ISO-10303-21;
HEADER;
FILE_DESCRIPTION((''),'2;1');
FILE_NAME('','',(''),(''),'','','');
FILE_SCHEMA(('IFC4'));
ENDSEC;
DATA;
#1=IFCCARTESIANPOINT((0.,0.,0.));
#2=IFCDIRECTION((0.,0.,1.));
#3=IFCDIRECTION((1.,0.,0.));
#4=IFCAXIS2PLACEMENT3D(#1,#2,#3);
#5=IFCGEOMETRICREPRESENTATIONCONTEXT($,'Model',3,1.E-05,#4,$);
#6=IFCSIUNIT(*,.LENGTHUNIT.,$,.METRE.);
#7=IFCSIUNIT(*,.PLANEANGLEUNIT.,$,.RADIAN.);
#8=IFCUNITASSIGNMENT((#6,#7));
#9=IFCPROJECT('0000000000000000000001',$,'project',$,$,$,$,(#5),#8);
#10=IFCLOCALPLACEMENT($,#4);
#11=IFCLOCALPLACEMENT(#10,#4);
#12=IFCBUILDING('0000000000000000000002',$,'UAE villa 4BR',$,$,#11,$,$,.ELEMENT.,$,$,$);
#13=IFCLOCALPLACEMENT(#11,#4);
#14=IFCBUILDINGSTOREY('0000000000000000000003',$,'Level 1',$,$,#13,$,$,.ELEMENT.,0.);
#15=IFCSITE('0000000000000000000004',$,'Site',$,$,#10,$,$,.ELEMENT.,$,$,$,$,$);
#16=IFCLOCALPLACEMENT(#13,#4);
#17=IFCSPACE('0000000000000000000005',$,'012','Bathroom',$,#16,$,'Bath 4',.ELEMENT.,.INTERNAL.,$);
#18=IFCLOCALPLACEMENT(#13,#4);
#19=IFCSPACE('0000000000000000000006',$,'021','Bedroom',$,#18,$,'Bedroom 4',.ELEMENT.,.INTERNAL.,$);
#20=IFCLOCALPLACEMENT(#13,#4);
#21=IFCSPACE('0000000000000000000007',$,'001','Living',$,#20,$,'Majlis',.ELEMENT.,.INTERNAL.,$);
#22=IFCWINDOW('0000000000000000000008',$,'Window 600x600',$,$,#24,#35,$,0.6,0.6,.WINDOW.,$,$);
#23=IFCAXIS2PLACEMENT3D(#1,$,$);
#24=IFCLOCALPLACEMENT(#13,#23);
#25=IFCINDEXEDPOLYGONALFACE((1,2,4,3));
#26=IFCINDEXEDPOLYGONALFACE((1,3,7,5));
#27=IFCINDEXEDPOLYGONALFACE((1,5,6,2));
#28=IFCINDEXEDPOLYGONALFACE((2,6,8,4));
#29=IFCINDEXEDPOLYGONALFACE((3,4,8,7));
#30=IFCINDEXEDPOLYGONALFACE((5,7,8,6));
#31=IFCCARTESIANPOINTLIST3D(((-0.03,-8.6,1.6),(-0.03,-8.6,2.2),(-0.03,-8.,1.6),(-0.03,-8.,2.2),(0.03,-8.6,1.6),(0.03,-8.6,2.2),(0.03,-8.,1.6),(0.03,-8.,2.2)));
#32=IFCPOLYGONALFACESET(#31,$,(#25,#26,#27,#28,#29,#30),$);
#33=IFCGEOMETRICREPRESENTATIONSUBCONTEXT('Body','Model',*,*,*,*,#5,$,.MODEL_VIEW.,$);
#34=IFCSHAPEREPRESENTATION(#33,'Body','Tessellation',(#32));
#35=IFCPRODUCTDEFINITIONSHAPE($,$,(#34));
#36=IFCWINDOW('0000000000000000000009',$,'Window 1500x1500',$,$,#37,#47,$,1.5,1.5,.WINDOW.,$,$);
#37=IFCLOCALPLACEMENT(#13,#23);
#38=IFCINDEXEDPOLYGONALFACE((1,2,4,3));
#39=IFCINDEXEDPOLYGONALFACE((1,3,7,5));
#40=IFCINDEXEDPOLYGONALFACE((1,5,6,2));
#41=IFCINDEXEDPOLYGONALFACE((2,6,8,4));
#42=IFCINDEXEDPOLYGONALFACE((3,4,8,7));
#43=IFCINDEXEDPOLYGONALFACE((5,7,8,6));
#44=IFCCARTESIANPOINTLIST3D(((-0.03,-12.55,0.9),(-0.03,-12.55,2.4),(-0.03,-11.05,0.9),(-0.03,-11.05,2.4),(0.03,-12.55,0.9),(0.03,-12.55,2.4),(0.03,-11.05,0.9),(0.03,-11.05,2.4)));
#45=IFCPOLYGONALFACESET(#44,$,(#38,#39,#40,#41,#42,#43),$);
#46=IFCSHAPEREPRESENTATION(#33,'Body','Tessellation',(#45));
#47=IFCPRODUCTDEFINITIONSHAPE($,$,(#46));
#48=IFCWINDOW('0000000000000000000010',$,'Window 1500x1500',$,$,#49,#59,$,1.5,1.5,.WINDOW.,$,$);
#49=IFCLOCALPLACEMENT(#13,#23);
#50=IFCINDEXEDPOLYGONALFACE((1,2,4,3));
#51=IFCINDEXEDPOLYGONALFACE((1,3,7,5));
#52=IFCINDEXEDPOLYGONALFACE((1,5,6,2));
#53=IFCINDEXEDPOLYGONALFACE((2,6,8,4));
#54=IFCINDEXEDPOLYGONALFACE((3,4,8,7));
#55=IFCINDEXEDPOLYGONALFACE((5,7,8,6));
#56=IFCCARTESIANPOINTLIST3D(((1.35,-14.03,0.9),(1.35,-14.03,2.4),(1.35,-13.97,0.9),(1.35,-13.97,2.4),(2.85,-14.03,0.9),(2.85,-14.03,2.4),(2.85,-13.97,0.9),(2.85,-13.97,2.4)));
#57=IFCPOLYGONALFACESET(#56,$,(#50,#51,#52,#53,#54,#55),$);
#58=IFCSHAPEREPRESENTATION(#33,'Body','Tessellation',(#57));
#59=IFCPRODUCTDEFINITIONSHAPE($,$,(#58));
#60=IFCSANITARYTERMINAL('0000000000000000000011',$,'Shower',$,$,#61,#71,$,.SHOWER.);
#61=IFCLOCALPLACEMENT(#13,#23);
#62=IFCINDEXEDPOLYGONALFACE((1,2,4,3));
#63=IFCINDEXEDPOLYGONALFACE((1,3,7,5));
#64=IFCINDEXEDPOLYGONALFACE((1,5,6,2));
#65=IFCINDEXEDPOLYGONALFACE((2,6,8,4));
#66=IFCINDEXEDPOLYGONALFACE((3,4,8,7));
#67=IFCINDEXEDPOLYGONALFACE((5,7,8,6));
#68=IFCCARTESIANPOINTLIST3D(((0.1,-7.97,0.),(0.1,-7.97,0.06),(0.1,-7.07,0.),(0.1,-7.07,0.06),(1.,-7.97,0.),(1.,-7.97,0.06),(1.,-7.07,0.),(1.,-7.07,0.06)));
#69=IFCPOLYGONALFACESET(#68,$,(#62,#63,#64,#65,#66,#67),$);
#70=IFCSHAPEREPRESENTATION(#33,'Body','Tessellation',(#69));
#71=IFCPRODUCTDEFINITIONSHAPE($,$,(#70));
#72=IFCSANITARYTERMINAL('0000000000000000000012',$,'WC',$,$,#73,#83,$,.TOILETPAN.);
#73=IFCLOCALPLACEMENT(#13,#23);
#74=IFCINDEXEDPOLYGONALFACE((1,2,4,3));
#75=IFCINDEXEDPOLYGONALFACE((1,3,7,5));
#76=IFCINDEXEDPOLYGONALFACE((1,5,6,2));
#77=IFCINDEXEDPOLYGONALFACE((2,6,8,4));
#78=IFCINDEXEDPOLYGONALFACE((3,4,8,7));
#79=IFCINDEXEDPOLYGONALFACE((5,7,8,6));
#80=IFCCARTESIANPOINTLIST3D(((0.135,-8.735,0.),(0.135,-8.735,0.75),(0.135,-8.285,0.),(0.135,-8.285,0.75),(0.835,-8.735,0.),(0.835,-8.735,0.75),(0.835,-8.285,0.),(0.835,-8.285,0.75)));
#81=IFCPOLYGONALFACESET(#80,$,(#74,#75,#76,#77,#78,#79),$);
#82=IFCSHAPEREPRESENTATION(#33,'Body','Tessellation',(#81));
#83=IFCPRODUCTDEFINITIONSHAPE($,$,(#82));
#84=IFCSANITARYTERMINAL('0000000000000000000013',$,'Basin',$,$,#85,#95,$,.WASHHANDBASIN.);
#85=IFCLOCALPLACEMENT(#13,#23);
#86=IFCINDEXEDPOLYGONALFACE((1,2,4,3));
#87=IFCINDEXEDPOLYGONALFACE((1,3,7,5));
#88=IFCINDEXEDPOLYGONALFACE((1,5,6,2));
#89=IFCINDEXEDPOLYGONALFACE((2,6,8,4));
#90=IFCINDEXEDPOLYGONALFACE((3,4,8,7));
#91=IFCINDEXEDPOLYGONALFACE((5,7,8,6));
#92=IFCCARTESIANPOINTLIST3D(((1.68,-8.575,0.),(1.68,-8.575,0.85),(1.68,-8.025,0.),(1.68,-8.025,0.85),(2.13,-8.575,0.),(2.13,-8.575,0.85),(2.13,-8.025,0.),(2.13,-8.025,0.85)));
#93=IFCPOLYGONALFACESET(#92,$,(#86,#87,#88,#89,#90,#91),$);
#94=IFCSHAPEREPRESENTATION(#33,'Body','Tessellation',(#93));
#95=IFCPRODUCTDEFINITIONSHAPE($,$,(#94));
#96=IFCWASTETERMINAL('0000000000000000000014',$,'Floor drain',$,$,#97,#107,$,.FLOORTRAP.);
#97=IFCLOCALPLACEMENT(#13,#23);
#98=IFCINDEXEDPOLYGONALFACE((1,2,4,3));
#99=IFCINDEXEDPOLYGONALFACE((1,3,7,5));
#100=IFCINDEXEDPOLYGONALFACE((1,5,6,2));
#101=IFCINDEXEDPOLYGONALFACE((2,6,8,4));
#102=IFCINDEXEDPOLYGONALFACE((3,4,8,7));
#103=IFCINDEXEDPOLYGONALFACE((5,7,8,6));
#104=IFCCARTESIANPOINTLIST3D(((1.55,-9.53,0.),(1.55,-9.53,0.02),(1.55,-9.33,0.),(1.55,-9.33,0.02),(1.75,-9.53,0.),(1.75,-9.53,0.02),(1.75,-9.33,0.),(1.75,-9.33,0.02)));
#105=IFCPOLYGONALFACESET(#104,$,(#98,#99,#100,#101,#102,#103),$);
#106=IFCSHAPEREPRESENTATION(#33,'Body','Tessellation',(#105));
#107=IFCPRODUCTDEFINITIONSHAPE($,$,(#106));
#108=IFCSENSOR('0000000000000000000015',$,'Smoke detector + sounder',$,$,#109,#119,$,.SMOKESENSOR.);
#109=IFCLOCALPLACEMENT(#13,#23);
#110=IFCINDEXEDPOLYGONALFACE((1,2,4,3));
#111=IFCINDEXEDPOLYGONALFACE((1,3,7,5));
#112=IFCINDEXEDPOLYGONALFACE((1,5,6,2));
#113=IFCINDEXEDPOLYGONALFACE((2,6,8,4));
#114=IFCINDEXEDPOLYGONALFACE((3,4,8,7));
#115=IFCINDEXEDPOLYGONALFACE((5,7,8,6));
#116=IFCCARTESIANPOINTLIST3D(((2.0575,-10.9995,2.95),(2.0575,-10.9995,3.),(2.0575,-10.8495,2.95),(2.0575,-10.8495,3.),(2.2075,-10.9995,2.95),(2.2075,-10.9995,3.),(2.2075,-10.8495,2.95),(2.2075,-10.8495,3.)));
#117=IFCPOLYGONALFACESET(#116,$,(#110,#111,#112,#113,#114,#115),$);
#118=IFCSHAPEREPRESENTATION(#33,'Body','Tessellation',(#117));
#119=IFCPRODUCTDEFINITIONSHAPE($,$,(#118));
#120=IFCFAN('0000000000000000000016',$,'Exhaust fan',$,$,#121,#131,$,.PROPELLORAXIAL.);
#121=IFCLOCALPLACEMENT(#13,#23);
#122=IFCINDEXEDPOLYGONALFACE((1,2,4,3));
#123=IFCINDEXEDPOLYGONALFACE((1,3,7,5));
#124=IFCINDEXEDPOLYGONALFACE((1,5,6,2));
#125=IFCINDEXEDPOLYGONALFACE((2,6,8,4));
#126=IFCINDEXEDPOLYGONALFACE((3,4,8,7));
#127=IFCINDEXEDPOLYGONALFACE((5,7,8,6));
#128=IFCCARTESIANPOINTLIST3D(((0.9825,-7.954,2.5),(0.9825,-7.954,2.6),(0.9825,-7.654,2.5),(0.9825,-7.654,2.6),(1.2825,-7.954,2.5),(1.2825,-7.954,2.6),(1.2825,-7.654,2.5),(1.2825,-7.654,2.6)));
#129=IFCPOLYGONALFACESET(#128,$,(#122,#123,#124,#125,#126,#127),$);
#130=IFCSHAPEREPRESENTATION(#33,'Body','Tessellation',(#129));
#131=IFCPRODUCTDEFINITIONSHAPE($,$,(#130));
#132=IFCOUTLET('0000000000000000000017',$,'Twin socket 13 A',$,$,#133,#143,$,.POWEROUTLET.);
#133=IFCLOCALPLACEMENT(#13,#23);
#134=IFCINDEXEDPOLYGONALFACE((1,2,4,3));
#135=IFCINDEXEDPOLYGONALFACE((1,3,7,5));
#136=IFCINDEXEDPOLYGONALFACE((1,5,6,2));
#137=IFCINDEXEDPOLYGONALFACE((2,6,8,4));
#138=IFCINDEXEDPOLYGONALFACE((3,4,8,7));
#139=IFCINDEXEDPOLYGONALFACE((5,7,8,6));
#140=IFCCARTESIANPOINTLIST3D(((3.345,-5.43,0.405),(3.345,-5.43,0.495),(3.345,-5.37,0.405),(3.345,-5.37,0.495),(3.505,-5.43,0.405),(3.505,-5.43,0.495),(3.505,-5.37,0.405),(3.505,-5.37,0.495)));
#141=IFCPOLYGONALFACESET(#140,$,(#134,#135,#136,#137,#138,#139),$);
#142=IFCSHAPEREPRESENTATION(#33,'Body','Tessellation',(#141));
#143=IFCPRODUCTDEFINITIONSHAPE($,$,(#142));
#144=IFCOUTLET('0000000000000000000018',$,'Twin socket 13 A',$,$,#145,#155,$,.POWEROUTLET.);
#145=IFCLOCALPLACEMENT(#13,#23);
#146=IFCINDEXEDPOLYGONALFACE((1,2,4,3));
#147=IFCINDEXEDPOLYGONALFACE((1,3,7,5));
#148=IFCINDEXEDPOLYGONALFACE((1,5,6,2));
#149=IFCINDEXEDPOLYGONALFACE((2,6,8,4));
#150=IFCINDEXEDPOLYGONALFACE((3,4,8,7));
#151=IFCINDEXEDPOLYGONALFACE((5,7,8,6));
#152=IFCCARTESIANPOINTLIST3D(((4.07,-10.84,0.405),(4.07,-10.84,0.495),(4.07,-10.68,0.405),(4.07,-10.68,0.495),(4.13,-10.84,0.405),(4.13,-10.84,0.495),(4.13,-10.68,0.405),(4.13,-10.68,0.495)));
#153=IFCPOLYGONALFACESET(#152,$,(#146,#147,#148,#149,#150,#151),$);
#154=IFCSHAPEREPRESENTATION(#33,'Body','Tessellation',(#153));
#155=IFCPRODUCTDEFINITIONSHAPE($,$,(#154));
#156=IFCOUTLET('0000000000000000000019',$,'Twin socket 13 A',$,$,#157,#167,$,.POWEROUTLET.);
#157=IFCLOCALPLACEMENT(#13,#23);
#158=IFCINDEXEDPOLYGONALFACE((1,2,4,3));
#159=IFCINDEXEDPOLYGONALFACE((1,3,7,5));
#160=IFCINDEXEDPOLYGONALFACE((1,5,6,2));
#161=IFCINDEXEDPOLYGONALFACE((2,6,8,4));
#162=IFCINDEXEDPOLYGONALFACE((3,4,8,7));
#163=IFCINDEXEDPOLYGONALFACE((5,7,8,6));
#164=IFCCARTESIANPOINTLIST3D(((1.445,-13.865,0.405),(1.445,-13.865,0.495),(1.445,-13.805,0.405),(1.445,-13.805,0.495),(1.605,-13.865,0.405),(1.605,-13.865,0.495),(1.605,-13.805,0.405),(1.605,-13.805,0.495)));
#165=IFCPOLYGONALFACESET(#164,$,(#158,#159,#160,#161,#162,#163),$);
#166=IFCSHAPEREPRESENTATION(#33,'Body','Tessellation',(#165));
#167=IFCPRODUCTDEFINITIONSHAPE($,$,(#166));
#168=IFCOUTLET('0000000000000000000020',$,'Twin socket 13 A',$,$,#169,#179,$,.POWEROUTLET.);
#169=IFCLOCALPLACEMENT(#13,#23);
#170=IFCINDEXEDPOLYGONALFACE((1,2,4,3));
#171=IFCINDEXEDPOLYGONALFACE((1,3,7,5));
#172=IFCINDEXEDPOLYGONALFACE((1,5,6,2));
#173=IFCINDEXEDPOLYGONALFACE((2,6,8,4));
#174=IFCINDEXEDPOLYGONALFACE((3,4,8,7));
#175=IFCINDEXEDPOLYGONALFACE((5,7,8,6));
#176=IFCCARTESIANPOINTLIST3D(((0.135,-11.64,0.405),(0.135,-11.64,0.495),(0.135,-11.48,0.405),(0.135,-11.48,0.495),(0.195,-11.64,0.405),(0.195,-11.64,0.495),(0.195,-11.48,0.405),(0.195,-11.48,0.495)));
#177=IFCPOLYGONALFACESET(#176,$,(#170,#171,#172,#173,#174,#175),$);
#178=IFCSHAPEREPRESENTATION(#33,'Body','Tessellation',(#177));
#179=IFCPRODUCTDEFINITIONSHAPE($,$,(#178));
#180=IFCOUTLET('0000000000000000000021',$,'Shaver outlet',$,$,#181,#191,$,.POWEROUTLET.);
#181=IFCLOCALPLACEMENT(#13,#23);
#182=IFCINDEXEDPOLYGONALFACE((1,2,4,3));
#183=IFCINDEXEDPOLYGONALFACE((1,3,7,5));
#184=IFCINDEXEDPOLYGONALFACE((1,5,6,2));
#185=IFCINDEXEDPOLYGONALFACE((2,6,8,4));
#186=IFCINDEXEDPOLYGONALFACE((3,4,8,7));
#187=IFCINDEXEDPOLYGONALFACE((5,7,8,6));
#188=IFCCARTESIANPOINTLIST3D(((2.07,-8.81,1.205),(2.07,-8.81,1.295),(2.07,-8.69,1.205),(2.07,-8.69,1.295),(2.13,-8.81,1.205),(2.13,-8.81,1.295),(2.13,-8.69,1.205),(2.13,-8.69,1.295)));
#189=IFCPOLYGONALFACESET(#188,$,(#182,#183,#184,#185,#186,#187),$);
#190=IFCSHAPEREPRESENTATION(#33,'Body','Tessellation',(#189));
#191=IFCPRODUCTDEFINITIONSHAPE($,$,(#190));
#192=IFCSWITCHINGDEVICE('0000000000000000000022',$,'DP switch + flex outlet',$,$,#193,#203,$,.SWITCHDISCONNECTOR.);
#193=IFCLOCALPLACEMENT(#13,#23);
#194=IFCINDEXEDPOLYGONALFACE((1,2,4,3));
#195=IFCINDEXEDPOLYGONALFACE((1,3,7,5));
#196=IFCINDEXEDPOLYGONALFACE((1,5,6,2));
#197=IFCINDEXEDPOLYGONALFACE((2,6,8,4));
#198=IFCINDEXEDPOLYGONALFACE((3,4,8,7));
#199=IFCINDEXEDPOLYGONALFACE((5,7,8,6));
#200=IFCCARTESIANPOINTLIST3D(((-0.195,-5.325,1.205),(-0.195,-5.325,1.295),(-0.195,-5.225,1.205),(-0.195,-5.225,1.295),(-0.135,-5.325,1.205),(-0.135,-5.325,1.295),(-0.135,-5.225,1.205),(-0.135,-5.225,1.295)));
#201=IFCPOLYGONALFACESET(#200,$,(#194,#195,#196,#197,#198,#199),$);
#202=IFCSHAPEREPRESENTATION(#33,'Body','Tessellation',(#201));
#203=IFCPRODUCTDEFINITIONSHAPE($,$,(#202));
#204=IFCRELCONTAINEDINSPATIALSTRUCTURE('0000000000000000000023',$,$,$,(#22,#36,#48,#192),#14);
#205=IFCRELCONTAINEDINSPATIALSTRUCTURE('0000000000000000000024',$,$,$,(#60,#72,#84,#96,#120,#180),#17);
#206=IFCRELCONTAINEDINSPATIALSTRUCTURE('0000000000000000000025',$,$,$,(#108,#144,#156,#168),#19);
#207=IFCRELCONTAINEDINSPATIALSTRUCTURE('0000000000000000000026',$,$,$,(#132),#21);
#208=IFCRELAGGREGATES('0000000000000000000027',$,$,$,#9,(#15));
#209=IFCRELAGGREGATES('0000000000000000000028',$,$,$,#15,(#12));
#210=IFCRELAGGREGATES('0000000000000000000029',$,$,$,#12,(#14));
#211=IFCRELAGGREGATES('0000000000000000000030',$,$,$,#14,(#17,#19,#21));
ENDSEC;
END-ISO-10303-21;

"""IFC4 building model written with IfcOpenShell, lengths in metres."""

from ifc_helpers import new_model, si_unit, frame, origin, origin_with_axes, origin_2d, place, context, subcontext, project, spatial, rectangle, extrude, element, save


model = new_model("IFC4")

# Units and contexts
model_context = context("Model", 3, precision=1e-05, world=origin_with_axes())
body_context = subcontext(model_context, "Body", "Model", "MODEL_VIEW")
ifc_project = project(units=[si_unit("LENGTHUNIT", "METRE"), si_unit("PLANEANGLEUNIT", "RADIAN")], contexts=[model_context])

# Site, building, storey
site_placement = place(None, origin_with_axes())
site = spatial("IfcSite", under=ifc_project, at=site_placement, Name="Site", CompositionType="ELEMENT")
building_placement = place(site_placement, origin_with_axes())
building = spatial("IfcBuilding", under=site, at=building_placement, Name="UAE villa 4BR", CompositionType="ELEMENT")
storey_placement = place(building_placement, origin_with_axes())
storey = spatial("IfcBuildingStorey", under=building, at=storey_placement, Name="Level 1", CompositionType="ELEMENT", Elevation=0.0)

# Windows
window_1_placement = place(storey_placement, frame((0.0, -8.3, 1.6), z_axis=(0.0, 0.0, 1.0), x_axis=(0.0, 1.0, 0.0)))
element("IfcWindow", 1, at=window_1_placement, inside=storey, Name="Window 600x600", OverallHeight=0.6, OverallWidth=0.6, PredefinedType="WINDOW", context=body_context, shape_type="SweptSolid", body=[
    extrude(rectangle(XDim=0.6, YDim=0.06, at=origin_2d()), origin(), (0.0, 0.0, 1.0), 0.6),
])
for number, where, z_axis, x_axis, name in (
    (2, (0.0, -11.8, 0.9), (0.0, 0.0, 1.0), (0.0, 1.0, 0.0), "Window 1500x1500"),
    (3, (2.1, -14.0, 0.9), (0.0, 0.0, 1.0), (-1.0, 0.0, 0.0), "Window 1500x1500"),
):
    element("IfcWindow", number, at=place(storey_placement, frame(where, z_axis=z_axis, x_axis=x_axis)), inside=storey, Name=name, OverallHeight=1.5, OverallWidth=1.5, PredefinedType="WINDOW", context=body_context, shape_type="SweptSolid", body=[
        extrude(rectangle(XDim=1.5, YDim=0.06, at=origin_2d()), origin(), (0.0, 0.0, 1.0), 1.5),
    ])

# Shared definitions
space_1_placement = place(storey_placement, origin_with_axes())
space_1 = spatial("IfcSpace", under=storey, at=space_1_placement, Name="012", Description="Bathroom", LongName="Bath 4", CompositionType="ELEMENT", PredefinedType="INTERNAL")

# Sanitary terminals
sanitary_terminal_1_placement = place(storey_placement, frame((0.55, -7.52, 0.0), z_axis=(0.0, 0.0, 1.0), x_axis=(1.0, 0.0, 0.0)))
element("IfcSanitaryTerminal", 4, at=sanitary_terminal_1_placement, inside=space_1, Name="Shower", PredefinedType="SHOWER", context=body_context, shape_type="SweptSolid", body=[
    extrude(rectangle(XDim=0.9, YDim=0.9, at=origin_2d()), origin(), (0.0, 0.0, 1.0), 0.06),
])
sanitary_terminal_2_placement = place(storey_placement, frame((0.485, -8.51, 0.0), z_axis=(0.0, 0.0, 1.0), x_axis=(0.0, 1.0, 0.0)))
element("IfcSanitaryTerminal", 5, at=sanitary_terminal_2_placement, inside=space_1, Name="WC", PredefinedType="TOILETPAN", context=body_context, shape_type="SweptSolid", body=[
    extrude(rectangle(XDim=0.45, YDim=0.7, at=origin_2d()), origin(), (0.0, 0.0, 1.0), 0.75),
])
sanitary_terminal_3_placement = place(storey_placement, frame((1.905, -8.3, 0.0), z_axis=(0.0, 0.0, 1.0), x_axis=(0.0, -1.0, 0.0)))
element("IfcSanitaryTerminal", 6, at=sanitary_terminal_3_placement, inside=space_1, Name="Basin", PredefinedType="WASHHANDBASIN", context=body_context, shape_type="SweptSolid", body=[
    extrude(rectangle(XDim=0.55, YDim=0.45, at=origin_2d()), origin(), (0.0, 0.0, 1.0), 0.85),
])

# Waste terminal
waste_terminal_placement = place(storey_placement, frame((1.65, -9.43, 0.0), z_axis=(0.0, 0.0, 1.0), x_axis=(-1.0, 0.0, 0.0)))
element("IfcWasteTerminal", 7, at=waste_terminal_placement, inside=space_1, Name="Floor drain", PredefinedType="FLOORTRAP", context=body_context, shape_type="SweptSolid", body=[
    extrude(rectangle(XDim=0.2, YDim=0.2, at=origin_2d()), origin(), (0.0, 0.0, 1.0), 0.02),
])

# Shared definitions
space_2_placement = place(storey_placement, origin_with_axes())
space_2 = spatial("IfcSpace", under=storey, at=space_2_placement, Name="021", Description="Bedroom", LongName="Bedroom 4", CompositionType="ELEMENT", PredefinedType="INTERNAL")

# Sensor
sensor_placement = place(storey_placement, frame((2.1325, -10.9245, 2.95), z_axis=(0.0, 0.0, 1.0), x_axis=(1.0, 0.0, 0.0)))
element("IfcSensor", 8, at=sensor_placement, inside=space_2, Name="Smoke detector + sounder", PredefinedType="SMOKESENSOR", context=body_context, shape_type="SweptSolid", body=[
    extrude(rectangle(XDim=0.15, YDim=0.15, at=origin_2d()), origin(), (0.0, 0.0, 1.0), 0.05),
])

# Fan
fan_placement = place(storey_placement, frame((1.1325, -7.804, 2.5), z_axis=(0.0, 0.0, 1.0), x_axis=(1.0, 0.0, 0.0)))
element("IfcFan", 9, at=fan_placement, inside=space_1, Name="Exhaust fan", PredefinedType="PROPELLORAXIAL", context=body_context, shape_type="SweptSolid", body=[
    extrude(rectangle(XDim=0.3, YDim=0.3, at=origin_2d()), origin(), (0.0, 0.0, 1.0), 0.1),
])

# Shared definitions
space_3_placement = place(storey_placement, origin_with_axes())
space_3 = spatial("IfcSpace", under=storey, at=space_3_placement, Name="001", Description="Living", LongName="Majlis", CompositionType="ELEMENT", PredefinedType="INTERNAL")

# Outlets
outlet_1_placement = place(storey_placement, frame((3.425, -5.4, 0.405), z_axis=(0.0, 0.0, 1.0), x_axis=(-1.0, 0.0, 0.0)))
element("IfcOutlet", 10, at=outlet_1_placement, inside=space_3, Name="Twin socket 13 A", PredefinedType="POWEROUTLET", context=body_context, shape_type="SweptSolid", body=[
    extrude(rectangle(XDim=0.16, YDim=0.06, at=origin_2d()), origin(), (0.0, 0.0, 1.0), 0.09),
])
for number, where, z_axis, x_axis, name in (
    (11, (4.1, -10.76, 0.405), (0.0, 0.0, 1.0), (0.0, -1.0, 0.0), "Twin socket 13 A"),
    (12, (1.525, -13.835, 0.405), (0.0, 0.0, 1.0), (-1.0, 0.0, 0.0), "Twin socket 13 A"),
    (13, (0.165, -11.56, 0.405), (0.0, 0.0, 1.0), (0.0, 1.0, 0.0), "Twin socket 13 A"),
):
    element("IfcOutlet", number, at=place(storey_placement, frame(where, z_axis=z_axis, x_axis=x_axis)), inside=space_2, Name=name, PredefinedType="POWEROUTLET", context=body_context, shape_type="SweptSolid", body=[
        extrude(rectangle(XDim=0.16, YDim=0.06, at=origin_2d()), origin(), (0.0, 0.0, 1.0), 0.09),
    ])
outlet_2_placement = place(storey_placement, frame((2.1, -8.75, 1.205), z_axis=(0.0, 0.0, 1.0), x_axis=(0.0, -1.0, 0.0)))
element("IfcOutlet", 14, at=outlet_2_placement, inside=space_1, Name="Shaver outlet", PredefinedType="POWEROUTLET", context=body_context, shape_type="SweptSolid", body=[
    extrude(rectangle(XDim=0.12, YDim=0.06, at=origin_2d()), origin(), (0.0, 0.0, 1.0), 0.09),
])

# Switching device
switching_device_placement = place(storey_placement, frame((-0.165, -5.275, 1.205), z_axis=(0.0, 0.0, 1.0), x_axis=(0.0, -1.0, 0.0)))
element("IfcSwitchingDevice", 15, at=switching_device_placement, inside=storey, Name="DP switch + flex outlet", PredefinedType="SWITCHDISCONNECTOR", context=body_context, shape_type="SweptSolid", body=[
    extrude(rectangle(XDim=0.1, YDim=0.06, at=origin_2d()), origin(), (0.0, 0.0, 1.0), 0.09),
])

save(model, "model.ifc")
